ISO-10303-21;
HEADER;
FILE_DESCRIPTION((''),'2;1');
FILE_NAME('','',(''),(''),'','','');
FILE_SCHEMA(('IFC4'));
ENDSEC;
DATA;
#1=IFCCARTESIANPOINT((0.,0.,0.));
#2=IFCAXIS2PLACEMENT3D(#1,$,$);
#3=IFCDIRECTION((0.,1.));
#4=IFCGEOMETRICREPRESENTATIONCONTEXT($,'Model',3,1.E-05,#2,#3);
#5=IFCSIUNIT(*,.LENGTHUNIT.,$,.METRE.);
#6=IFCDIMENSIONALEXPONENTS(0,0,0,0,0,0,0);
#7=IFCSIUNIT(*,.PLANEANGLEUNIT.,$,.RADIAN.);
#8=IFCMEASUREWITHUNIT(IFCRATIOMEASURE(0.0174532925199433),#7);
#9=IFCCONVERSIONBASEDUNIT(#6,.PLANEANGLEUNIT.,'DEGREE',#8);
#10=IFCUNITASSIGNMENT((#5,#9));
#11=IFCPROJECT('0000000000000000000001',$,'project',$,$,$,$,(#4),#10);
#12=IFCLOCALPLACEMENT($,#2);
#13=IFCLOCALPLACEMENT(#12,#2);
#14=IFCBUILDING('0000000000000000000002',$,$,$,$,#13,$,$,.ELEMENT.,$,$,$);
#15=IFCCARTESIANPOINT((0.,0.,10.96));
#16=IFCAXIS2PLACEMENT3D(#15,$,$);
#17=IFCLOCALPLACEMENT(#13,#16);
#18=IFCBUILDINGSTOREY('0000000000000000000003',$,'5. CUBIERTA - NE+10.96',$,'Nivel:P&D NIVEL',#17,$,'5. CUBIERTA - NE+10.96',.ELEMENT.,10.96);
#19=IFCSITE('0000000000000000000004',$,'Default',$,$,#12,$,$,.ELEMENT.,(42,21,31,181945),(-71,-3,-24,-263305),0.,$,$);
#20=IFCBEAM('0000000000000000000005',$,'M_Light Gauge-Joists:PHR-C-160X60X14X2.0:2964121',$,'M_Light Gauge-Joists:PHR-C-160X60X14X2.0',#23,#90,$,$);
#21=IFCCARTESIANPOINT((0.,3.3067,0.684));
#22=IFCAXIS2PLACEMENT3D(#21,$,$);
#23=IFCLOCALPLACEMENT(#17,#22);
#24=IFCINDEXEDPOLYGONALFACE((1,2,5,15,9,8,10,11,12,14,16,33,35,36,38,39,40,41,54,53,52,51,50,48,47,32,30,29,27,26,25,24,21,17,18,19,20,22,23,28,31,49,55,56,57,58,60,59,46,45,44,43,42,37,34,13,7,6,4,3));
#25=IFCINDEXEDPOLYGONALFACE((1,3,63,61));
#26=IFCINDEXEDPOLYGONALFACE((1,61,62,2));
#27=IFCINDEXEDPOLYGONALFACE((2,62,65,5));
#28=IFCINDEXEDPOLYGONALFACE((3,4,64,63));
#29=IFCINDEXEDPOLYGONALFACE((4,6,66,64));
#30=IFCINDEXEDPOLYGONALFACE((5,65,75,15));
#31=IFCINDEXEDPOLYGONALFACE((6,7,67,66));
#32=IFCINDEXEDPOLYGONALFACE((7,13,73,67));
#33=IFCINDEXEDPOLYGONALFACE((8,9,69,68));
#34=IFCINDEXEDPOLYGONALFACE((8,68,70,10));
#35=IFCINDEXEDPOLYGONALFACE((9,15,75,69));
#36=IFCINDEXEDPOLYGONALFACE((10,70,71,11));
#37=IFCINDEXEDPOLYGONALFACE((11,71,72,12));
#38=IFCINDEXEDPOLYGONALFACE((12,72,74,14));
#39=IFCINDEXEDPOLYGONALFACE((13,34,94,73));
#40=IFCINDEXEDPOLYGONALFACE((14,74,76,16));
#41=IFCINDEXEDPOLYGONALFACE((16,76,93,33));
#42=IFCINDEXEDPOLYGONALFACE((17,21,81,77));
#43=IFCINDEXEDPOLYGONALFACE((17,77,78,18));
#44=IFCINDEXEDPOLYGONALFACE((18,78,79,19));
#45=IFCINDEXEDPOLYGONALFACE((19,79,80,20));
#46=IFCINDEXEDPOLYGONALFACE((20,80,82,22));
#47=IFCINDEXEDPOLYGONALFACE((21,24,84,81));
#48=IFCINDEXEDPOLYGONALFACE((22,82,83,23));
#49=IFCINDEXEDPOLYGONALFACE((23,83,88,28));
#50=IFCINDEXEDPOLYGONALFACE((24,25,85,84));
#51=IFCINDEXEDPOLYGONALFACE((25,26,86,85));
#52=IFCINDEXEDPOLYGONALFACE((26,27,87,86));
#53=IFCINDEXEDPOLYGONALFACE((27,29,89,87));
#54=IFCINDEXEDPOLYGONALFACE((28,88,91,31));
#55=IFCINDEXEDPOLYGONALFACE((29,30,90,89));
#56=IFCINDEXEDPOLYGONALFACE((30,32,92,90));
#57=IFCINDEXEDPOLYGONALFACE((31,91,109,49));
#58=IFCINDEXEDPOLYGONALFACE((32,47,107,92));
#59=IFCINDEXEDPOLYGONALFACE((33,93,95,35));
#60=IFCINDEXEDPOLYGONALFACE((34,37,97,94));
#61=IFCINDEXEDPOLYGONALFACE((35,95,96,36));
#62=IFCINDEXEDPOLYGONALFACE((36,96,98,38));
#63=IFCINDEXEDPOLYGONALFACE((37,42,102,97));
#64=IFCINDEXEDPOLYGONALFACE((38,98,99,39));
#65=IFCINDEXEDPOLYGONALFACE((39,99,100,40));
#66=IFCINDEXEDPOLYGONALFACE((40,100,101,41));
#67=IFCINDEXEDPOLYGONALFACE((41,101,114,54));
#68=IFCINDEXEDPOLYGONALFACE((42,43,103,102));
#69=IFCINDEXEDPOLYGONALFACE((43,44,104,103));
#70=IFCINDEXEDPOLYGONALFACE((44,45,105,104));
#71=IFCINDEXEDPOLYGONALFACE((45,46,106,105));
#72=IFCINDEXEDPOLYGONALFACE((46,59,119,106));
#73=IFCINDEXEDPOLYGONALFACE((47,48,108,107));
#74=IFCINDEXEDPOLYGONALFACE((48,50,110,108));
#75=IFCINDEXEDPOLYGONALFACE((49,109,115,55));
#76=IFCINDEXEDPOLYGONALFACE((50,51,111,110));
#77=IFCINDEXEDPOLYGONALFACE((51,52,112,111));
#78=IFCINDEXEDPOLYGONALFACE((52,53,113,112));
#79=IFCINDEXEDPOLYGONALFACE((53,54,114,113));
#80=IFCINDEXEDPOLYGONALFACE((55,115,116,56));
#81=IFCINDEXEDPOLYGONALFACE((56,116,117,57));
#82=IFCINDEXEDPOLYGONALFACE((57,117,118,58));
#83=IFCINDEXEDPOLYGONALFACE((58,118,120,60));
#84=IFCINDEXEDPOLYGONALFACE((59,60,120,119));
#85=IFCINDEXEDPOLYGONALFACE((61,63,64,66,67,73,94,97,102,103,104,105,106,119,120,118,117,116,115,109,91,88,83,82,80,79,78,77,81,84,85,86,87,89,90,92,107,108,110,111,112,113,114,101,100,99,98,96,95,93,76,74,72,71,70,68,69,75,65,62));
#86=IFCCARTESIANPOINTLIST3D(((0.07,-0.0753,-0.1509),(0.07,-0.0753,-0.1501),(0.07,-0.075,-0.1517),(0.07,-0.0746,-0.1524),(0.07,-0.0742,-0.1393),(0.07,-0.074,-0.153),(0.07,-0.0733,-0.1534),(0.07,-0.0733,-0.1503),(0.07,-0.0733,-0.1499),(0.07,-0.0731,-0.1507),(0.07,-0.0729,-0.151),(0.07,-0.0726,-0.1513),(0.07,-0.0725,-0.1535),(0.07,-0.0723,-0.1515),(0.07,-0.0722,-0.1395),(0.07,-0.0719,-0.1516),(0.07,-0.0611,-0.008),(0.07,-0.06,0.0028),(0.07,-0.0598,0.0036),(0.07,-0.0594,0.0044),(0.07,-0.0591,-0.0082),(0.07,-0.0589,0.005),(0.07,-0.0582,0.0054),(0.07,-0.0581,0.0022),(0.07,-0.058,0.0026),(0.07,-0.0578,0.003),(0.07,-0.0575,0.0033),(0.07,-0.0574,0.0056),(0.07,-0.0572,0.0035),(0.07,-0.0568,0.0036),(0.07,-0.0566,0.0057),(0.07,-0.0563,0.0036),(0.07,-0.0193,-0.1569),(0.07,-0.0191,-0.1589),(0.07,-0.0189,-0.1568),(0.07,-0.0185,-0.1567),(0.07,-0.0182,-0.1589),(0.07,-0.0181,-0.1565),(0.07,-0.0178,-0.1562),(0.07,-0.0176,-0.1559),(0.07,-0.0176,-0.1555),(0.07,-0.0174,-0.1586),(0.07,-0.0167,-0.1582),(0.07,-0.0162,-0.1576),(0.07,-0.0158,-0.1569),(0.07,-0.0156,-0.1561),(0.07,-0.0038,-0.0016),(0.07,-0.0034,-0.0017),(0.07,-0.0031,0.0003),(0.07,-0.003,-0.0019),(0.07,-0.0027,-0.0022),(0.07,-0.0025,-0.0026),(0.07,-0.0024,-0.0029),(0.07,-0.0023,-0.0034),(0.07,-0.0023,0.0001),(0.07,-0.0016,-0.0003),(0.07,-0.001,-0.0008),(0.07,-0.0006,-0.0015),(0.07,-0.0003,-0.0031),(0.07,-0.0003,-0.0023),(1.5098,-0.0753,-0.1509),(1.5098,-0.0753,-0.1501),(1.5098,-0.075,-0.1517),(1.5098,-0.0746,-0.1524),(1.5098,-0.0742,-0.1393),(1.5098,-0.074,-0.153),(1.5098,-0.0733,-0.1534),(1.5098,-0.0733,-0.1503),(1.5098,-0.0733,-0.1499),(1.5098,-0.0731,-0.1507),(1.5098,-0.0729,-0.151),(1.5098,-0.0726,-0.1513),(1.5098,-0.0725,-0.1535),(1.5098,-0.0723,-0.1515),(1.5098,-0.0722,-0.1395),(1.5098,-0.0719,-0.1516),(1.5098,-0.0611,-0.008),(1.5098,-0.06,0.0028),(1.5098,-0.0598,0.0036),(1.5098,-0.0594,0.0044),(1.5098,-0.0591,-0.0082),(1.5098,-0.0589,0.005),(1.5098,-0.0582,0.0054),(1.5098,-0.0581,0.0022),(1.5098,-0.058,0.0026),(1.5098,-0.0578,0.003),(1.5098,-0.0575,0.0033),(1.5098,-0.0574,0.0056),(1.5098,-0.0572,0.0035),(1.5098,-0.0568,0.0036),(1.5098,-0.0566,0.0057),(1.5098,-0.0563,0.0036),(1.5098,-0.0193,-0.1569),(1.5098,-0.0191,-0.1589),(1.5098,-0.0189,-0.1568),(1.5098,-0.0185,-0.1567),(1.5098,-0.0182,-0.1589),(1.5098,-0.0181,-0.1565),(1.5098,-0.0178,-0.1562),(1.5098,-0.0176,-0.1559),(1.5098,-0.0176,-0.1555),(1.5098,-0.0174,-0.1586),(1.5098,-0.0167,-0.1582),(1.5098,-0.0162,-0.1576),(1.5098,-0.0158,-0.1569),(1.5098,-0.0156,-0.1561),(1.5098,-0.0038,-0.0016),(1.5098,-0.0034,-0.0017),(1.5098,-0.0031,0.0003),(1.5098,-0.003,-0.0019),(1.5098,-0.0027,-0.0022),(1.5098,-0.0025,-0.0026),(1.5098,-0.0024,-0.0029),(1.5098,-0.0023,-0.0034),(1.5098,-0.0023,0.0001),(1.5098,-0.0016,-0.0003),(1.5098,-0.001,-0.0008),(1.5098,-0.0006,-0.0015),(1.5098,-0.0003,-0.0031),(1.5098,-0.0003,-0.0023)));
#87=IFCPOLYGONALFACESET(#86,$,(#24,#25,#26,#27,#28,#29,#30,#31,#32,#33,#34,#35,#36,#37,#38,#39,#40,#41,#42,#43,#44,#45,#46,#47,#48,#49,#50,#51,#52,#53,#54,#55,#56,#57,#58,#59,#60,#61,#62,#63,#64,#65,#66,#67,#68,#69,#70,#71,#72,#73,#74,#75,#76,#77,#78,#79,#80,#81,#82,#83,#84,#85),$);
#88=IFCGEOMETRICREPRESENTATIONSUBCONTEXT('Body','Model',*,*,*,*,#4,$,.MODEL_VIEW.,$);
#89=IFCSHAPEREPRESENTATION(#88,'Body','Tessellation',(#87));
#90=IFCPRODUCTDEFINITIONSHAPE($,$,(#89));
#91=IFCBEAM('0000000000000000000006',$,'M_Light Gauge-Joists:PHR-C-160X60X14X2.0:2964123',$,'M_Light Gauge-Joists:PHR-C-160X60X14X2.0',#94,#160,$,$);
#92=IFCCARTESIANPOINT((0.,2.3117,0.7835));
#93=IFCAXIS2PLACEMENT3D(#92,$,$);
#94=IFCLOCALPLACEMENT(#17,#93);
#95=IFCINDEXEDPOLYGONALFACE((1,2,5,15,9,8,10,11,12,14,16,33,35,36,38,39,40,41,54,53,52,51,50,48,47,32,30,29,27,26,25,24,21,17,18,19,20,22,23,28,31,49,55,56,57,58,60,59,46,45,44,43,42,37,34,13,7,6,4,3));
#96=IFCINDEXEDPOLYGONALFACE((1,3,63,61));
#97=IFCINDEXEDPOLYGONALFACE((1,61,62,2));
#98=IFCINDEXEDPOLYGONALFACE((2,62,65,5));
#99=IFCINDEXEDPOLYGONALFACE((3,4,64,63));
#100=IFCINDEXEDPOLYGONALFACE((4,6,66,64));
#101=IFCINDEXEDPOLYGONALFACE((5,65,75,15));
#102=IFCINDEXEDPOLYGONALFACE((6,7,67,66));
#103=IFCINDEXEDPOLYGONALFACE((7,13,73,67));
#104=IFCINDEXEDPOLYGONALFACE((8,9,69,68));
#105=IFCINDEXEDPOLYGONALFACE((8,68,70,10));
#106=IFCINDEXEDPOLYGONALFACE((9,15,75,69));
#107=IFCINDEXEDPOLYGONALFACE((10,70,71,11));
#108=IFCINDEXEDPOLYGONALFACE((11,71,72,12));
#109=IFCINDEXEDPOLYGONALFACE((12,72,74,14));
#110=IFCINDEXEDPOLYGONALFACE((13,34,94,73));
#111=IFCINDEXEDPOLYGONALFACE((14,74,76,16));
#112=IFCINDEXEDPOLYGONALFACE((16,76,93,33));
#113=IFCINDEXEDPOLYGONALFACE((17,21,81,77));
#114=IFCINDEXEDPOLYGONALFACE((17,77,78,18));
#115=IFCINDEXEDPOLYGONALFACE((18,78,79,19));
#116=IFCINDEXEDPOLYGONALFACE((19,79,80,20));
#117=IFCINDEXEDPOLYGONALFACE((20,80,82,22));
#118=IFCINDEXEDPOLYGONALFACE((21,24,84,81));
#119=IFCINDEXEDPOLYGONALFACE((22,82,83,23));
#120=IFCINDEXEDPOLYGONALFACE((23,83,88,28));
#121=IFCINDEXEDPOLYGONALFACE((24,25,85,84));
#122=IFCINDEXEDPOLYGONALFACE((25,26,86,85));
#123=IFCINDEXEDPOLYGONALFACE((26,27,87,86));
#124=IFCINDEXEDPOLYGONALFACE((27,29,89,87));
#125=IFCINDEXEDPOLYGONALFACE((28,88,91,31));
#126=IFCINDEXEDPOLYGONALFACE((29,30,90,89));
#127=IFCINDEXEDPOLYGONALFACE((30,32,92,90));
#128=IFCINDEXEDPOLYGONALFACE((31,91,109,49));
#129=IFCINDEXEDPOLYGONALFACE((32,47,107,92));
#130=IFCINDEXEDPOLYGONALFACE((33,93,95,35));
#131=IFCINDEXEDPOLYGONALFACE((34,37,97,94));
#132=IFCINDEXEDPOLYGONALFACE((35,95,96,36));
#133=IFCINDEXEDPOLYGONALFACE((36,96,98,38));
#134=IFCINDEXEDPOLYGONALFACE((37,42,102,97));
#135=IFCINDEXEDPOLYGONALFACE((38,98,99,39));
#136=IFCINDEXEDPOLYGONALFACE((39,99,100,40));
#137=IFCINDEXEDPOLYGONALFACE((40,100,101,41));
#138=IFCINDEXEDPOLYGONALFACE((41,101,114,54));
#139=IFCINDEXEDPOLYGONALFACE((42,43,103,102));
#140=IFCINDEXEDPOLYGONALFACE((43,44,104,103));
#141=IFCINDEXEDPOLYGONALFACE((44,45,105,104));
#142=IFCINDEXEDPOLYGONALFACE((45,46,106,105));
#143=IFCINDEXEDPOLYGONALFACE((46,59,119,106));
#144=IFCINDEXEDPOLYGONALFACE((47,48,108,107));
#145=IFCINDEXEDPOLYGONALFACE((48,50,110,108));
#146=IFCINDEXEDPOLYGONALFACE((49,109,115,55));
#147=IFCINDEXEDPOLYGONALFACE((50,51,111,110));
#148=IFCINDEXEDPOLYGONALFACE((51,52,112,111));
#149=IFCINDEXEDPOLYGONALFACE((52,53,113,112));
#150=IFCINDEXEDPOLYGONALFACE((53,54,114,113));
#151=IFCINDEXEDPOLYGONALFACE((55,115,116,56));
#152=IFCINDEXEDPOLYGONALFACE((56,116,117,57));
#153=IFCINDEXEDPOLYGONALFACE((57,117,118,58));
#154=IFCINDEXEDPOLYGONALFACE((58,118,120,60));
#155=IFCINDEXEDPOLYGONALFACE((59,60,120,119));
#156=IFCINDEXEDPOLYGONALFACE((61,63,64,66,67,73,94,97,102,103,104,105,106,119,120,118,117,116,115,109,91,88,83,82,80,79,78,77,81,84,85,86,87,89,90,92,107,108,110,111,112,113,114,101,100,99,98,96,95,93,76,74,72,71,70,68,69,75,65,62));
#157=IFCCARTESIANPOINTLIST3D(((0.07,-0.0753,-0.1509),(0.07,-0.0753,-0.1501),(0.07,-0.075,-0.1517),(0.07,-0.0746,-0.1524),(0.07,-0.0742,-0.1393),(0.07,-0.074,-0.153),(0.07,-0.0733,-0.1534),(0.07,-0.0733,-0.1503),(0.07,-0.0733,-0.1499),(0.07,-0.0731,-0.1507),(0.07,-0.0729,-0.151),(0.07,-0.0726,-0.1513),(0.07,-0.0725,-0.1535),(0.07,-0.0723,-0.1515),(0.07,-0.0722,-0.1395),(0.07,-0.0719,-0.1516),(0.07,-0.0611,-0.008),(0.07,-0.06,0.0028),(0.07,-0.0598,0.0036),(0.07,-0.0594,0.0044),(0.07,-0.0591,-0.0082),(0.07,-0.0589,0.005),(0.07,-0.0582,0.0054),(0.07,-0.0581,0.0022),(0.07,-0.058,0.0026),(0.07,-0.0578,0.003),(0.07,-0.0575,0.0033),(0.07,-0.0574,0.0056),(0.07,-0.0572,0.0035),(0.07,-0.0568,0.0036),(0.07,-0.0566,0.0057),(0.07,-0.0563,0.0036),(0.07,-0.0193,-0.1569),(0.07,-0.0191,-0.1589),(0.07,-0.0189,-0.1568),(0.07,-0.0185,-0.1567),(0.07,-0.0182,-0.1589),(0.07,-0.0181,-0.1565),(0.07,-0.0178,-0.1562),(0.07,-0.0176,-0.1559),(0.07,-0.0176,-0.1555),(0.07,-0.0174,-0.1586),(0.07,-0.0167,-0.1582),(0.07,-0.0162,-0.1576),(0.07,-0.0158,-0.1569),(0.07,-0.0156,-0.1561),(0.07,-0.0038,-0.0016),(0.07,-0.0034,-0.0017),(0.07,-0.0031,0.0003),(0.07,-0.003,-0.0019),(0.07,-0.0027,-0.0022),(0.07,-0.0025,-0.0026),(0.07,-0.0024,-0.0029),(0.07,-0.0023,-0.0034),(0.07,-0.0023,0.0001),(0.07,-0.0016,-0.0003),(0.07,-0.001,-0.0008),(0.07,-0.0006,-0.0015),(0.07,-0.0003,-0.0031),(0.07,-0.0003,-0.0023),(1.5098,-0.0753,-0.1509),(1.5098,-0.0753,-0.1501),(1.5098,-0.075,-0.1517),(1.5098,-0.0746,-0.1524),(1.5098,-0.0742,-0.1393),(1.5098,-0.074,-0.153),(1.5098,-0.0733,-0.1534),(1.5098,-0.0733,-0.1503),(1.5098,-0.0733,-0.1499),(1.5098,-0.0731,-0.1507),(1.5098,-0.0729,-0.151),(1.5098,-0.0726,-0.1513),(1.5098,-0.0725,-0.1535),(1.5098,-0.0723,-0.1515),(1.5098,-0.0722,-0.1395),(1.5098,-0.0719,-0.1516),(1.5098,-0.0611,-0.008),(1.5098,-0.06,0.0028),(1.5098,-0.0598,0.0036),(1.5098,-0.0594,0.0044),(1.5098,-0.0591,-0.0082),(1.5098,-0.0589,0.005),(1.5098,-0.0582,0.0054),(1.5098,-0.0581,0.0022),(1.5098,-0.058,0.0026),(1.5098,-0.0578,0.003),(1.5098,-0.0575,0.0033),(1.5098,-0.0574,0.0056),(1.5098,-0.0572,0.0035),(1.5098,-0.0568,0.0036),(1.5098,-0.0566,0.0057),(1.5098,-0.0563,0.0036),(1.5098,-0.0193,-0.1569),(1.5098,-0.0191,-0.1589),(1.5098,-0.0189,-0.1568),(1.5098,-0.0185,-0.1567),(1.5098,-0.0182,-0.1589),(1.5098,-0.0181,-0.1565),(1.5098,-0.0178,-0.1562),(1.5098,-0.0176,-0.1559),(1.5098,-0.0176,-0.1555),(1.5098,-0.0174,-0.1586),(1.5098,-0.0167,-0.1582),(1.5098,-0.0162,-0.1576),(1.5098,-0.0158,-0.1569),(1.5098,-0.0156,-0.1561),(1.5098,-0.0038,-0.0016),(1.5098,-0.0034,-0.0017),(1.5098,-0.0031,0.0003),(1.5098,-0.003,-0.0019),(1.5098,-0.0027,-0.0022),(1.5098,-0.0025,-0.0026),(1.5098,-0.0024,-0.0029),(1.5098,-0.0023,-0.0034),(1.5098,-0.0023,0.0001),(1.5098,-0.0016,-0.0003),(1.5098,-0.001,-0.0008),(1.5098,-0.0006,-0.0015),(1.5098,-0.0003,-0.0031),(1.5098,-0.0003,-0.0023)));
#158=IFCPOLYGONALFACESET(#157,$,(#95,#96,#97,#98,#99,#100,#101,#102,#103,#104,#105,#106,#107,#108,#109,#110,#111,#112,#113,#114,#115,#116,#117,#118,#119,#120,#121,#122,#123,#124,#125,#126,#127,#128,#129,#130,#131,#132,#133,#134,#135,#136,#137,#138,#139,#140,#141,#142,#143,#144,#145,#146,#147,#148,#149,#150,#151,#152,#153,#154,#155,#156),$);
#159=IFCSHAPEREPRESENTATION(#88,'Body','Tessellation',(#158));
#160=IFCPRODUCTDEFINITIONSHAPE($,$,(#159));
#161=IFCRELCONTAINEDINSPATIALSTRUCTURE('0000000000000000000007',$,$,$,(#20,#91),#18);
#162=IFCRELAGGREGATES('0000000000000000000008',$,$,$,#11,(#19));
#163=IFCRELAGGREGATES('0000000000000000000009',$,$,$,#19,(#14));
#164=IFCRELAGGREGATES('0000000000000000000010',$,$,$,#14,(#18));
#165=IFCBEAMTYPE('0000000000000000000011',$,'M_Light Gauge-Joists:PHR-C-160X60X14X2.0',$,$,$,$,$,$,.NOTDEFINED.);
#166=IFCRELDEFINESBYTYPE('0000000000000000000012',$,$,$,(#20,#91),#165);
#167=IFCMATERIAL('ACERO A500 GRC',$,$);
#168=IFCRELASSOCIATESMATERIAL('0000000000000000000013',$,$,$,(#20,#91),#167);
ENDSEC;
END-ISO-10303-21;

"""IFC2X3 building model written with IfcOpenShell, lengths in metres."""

from ifc_helpers import new_model, entity, si_unit, converted_unit, direction, frame, frame_2d, origin, place, context, subcontext, project, spatial, polyline, circle_curve, parameter, trimmed, segment, composite_curve, outline, extrude, material, type_object, element, save


model = new_model("IFC2X3")

# Units and contexts
model_context = context("Model", 3, precision=1e-05, world=origin(), true_north=direction((0.0, 1.0)))
body_context = subcontext(model_context, "Body", "Model", "MODEL_VIEW")
ifc_project = project(units=[si_unit("LENGTHUNIT", "METRE"), converted_unit("PLANEANGLEUNIT", "DEGREE", entity("IfcRatioMeasure", 0.0174532925199433), si_unit("PLANEANGLEUNIT", "RADIAN"), dimensions=[0, 0, 0, 0, 0, 0, 0])], contexts=[model_context])

# Site, building, storey
site_placement = place(None, origin())
site = spatial("IfcSite", under=ifc_project, at=site_placement, Name="Default", CompositionType="ELEMENT", RefLatitude=(42, 21, 31, 181945), RefLongitude=(-71, -3, -24, -263305), RefElevation=0.0)
building_placement = place(site_placement, origin())
building = spatial("IfcBuilding", under=site, at=building_placement, CompositionType="ELEMENT")
storey_placement = place(building_placement, frame((0.0, 0.0, 10.96)))
storey = spatial("IfcBuildingStorey", under=building, at=storey_placement, Name="5. CUBIERTA - NE+10.96", ObjectType="Nivel:P&D NIVEL", LongName="5. CUBIERTA - NE+10.96", CompositionType="ELEMENT", Elevation=10.96)

# Beams
ifc_material_1 = material(Name="ACERO A500 GRC")
beam_type_1 = type_object("IfcBeamType", Name="M_Light Gauge-Joists:PHR-C-160X60X14X2.0", PredefinedType="NOTDEFINED")
beam_1_placement = place(storey_placement, frame((0.0, 3.3067, 0.684)))
element("IfcBeam", 1, at=beam_1_placement, inside=storey, type_object=beam_type_1, material=ifc_material_1, Name="M_Light Gauge-Joists:PHR-C-160X60X14X2.0:2964121", ObjectType="M_Light Gauge-Joists:PHR-C-160X60X14X2.0", context=body_context, shape_type="SweptSolid", body=[
    extrude(outline(composite_curve([segment(polyline([(-0.0768, -0.0358), (0.0768, -0.0358)]), True, "CONTINUOUS"), segment(trimmed(circle_curve(frame_2d((0.0768, -0.0326), x_axis=(0.0, -1.0)), 0.0032), [parameter(0.0)], [parameter(90.0)], True, "PARAMETER"), True, "CONTINUOUS"), segment(polyline([(0.08, -0.0326), (0.08, 0.021)]), True, "CONTINUOUS"), segment(trimmed(circle_curve(frame_2d((0.0768, 0.021), x_axis=(1.0, 0.0)), 0.0032), [parameter(0.0)], [parameter(90.0)], True, "PARAMETER"), True, "CONTINUOUS"), segment(polyline([(0.0768, 0.0242), (0.066, 0.0242)]), True, "CONTINUOUS"), segment(polyline([(0.066, 0.0242), (0.066, 0.0222)]), True, "CONTINUOUS"), segment(polyline([(0.066, 0.0222), (0.0764, 0.0222)]), True, "CONTINUOUS"), segment(trimmed(circle_curve(frame_2d((0.0764, 0.0206), x_axis=(0.0, 1.0)), 0.0016), [parameter(270.0)], [parameter(0.0)], True, "PARAMETER"), False, "CONTINUOUS"), segment(polyline([(0.078, 0.0206), (0.078, -0.0322)]), True, "CONTINUOUS"), segment(trimmed(circle_curve(frame_2d((0.0764, -0.0322), x_axis=(1.0, 0.0)), 0.0016), [parameter(270.0)], [parameter(0.0)], True, "PARAMETER"), False, "CONTINUOUS"), segment(polyline([(0.0764, -0.0338), (-0.0764, -0.0338)]), True, "CONTINUOUS"), segment(trimmed(circle_curve(frame_2d((-0.0764, -0.0322), x_axis=(0.0, -1.0)), 0.0016), [parameter(270.0)], [parameter(0.0)], True, "PARAMETER"), False, "CONTINUOUS"), segment(polyline([(-0.078, -0.0322), (-0.078, 0.0206)]), True, "CONTINUOUS"), segment(trimmed(circle_curve(frame_2d((-0.0764, 0.0206), x_axis=(-1.0, 0.0)), 0.0016), [parameter(270.0)], [parameter(0.0)], True, "PARAMETER"), False, "CONTINUOUS"), segment(polyline([(-0.0764, 0.0222), (-0.066, 0.0222)]), True, "CONTINUOUS"), segment(polyline([(-0.066, 0.0222), (-0.066, 0.0242)]), True, "CONTINUOUS"), segment(polyline([(-0.066, 0.0242), (-0.0768, 0.0242)]), True, "CONTINUOUS"), segment(trimmed(circle_curve(frame_2d((-0.0768, 0.021), x_axis=(0.0, 1.0)), 0.0032), [parameter(0.0)], [parameter(90.0)], True, "PARAMETER"), True, "CONTINUOUS"), segment(polyline([(-0.08, 0.021), (-0.08, -0.0326)]), True, "CONTINUOUS"), segment(trimmed(circle_curve(frame_2d((-0.0768, -0.0326), x_axis=(-1.0, 0.0)), 0.0032), [parameter(0.0)], [parameter(90.0)], True, "PARAMETER"), True, "CONTINUOUS")], self_intersect=False)), frame((0.07, -0.0436, -0.076), z_axis=(1.0, 0.0, 0.0), x_axis=(0.0, 0.099504, 0.995037)), (0.0, 0.0, 1.0), 1.4398),
])
beam_2_placement = place(storey_placement, frame((0.0, 2.3117, 0.7835)))
element("IfcBeam", 2, at=beam_2_placement, inside=storey, type_object=beam_type_1, material=ifc_material_1, Name="M_Light Gauge-Joists:PHR-C-160X60X14X2.0:2964123", ObjectType="M_Light Gauge-Joists:PHR-C-160X60X14X2.0", context=body_context, shape_type="SweptSolid", body=[
    extrude(outline(composite_curve([segment(polyline([(-0.0768, -0.0358), (0.0768, -0.0358)]), True, "CONTINUOUS"), segment(trimmed(circle_curve(frame_2d((0.0768, -0.0326), x_axis=(0.0, -1.0)), 0.0032), [parameter(0.0)], [parameter(90.0)], True, "PARAMETER"), True, "CONTINUOUS"), segment(polyline([(0.08, -0.0326), (0.08, 0.021)]), True, "CONTINUOUS"), segment(trimmed(circle_curve(frame_2d((0.0768, 0.021), x_axis=(1.0, 0.0)), 0.0032), [parameter(0.0)], [parameter(90.0)], True, "PARAMETER"), True, "CONTINUOUS"), segment(polyline([(0.0768, 0.0242), (0.066, 0.0242)]), True, "CONTINUOUS"), segment(polyline([(0.066, 0.0242), (0.066, 0.0222)]), True, "CONTINUOUS"), segment(polyline([(0.066, 0.0222), (0.0764, 0.0222)]), True, "CONTINUOUS"), segment(trimmed(circle_curve(frame_2d((0.0764, 0.0206), x_axis=(0.0, 1.0)), 0.0016), [parameter(270.0)], [parameter(0.0)], True, "PARAMETER"), False, "CONTINUOUS"), segment(polyline([(0.078, 0.0206), (0.078, -0.0322)]), True, "CONTINUOUS"), segment(trimmed(circle_curve(frame_2d((0.0764, -0.0322), x_axis=(1.0, 0.0)), 0.0016), [parameter(270.0)], [parameter(0.0)], True, "PARAMETER"), False, "CONTINUOUS"), segment(polyline([(0.0764, -0.0338), (-0.0764, -0.0338)]), True, "CONTINUOUS"), segment(trimmed(circle_curve(frame_2d((-0.0764, -0.0322), x_axis=(0.0, -1.0)), 0.0016), [parameter(270.0)], [parameter(0.0)], True, "PARAMETER"), False, "CONTINUOUS"), segment(polyline([(-0.078, -0.0322), (-0.078, 0.0206)]), True, "CONTINUOUS"), segment(trimmed(circle_curve(frame_2d((-0.0764, 0.0206), x_axis=(-1.0, 0.0)), 0.0016), [parameter(270.0)], [parameter(0.0)], True, "PARAMETER"), False, "CONTINUOUS"), segment(polyline([(-0.0764, 0.0222), (-0.066, 0.0222)]), True, "CONTINUOUS"), segment(polyline([(-0.066, 0.0222), (-0.066, 0.0242)]), True, "CONTINUOUS"), segment(polyline([(-0.066, 0.0242), (-0.0768, 0.0242)]), True, "CONTINUOUS"), segment(trimmed(circle_curve(frame_2d((-0.0768, 0.021), x_axis=(0.0, 1.0)), 0.0032), [parameter(0.0)], [parameter(90.0)], True, "PARAMETER"), True, "CONTINUOUS"), segment(polyline([(-0.08, 0.021), (-0.08, -0.0326)]), True, "CONTINUOUS"), segment(trimmed(circle_curve(frame_2d((-0.0768, -0.0326), x_axis=(-1.0, 0.0)), 0.0032), [parameter(0.0)], [parameter(90.0)], True, "PARAMETER"), True, "CONTINUOUS")], self_intersect=False)), frame((0.07, -0.0436, -0.076), z_axis=(1.0, 0.0, 0.0), x_axis=(0.0, 0.099504, 0.995037)), (0.0, 0.0, 1.0), 1.4398),
])

save(model, "model.ifc")
